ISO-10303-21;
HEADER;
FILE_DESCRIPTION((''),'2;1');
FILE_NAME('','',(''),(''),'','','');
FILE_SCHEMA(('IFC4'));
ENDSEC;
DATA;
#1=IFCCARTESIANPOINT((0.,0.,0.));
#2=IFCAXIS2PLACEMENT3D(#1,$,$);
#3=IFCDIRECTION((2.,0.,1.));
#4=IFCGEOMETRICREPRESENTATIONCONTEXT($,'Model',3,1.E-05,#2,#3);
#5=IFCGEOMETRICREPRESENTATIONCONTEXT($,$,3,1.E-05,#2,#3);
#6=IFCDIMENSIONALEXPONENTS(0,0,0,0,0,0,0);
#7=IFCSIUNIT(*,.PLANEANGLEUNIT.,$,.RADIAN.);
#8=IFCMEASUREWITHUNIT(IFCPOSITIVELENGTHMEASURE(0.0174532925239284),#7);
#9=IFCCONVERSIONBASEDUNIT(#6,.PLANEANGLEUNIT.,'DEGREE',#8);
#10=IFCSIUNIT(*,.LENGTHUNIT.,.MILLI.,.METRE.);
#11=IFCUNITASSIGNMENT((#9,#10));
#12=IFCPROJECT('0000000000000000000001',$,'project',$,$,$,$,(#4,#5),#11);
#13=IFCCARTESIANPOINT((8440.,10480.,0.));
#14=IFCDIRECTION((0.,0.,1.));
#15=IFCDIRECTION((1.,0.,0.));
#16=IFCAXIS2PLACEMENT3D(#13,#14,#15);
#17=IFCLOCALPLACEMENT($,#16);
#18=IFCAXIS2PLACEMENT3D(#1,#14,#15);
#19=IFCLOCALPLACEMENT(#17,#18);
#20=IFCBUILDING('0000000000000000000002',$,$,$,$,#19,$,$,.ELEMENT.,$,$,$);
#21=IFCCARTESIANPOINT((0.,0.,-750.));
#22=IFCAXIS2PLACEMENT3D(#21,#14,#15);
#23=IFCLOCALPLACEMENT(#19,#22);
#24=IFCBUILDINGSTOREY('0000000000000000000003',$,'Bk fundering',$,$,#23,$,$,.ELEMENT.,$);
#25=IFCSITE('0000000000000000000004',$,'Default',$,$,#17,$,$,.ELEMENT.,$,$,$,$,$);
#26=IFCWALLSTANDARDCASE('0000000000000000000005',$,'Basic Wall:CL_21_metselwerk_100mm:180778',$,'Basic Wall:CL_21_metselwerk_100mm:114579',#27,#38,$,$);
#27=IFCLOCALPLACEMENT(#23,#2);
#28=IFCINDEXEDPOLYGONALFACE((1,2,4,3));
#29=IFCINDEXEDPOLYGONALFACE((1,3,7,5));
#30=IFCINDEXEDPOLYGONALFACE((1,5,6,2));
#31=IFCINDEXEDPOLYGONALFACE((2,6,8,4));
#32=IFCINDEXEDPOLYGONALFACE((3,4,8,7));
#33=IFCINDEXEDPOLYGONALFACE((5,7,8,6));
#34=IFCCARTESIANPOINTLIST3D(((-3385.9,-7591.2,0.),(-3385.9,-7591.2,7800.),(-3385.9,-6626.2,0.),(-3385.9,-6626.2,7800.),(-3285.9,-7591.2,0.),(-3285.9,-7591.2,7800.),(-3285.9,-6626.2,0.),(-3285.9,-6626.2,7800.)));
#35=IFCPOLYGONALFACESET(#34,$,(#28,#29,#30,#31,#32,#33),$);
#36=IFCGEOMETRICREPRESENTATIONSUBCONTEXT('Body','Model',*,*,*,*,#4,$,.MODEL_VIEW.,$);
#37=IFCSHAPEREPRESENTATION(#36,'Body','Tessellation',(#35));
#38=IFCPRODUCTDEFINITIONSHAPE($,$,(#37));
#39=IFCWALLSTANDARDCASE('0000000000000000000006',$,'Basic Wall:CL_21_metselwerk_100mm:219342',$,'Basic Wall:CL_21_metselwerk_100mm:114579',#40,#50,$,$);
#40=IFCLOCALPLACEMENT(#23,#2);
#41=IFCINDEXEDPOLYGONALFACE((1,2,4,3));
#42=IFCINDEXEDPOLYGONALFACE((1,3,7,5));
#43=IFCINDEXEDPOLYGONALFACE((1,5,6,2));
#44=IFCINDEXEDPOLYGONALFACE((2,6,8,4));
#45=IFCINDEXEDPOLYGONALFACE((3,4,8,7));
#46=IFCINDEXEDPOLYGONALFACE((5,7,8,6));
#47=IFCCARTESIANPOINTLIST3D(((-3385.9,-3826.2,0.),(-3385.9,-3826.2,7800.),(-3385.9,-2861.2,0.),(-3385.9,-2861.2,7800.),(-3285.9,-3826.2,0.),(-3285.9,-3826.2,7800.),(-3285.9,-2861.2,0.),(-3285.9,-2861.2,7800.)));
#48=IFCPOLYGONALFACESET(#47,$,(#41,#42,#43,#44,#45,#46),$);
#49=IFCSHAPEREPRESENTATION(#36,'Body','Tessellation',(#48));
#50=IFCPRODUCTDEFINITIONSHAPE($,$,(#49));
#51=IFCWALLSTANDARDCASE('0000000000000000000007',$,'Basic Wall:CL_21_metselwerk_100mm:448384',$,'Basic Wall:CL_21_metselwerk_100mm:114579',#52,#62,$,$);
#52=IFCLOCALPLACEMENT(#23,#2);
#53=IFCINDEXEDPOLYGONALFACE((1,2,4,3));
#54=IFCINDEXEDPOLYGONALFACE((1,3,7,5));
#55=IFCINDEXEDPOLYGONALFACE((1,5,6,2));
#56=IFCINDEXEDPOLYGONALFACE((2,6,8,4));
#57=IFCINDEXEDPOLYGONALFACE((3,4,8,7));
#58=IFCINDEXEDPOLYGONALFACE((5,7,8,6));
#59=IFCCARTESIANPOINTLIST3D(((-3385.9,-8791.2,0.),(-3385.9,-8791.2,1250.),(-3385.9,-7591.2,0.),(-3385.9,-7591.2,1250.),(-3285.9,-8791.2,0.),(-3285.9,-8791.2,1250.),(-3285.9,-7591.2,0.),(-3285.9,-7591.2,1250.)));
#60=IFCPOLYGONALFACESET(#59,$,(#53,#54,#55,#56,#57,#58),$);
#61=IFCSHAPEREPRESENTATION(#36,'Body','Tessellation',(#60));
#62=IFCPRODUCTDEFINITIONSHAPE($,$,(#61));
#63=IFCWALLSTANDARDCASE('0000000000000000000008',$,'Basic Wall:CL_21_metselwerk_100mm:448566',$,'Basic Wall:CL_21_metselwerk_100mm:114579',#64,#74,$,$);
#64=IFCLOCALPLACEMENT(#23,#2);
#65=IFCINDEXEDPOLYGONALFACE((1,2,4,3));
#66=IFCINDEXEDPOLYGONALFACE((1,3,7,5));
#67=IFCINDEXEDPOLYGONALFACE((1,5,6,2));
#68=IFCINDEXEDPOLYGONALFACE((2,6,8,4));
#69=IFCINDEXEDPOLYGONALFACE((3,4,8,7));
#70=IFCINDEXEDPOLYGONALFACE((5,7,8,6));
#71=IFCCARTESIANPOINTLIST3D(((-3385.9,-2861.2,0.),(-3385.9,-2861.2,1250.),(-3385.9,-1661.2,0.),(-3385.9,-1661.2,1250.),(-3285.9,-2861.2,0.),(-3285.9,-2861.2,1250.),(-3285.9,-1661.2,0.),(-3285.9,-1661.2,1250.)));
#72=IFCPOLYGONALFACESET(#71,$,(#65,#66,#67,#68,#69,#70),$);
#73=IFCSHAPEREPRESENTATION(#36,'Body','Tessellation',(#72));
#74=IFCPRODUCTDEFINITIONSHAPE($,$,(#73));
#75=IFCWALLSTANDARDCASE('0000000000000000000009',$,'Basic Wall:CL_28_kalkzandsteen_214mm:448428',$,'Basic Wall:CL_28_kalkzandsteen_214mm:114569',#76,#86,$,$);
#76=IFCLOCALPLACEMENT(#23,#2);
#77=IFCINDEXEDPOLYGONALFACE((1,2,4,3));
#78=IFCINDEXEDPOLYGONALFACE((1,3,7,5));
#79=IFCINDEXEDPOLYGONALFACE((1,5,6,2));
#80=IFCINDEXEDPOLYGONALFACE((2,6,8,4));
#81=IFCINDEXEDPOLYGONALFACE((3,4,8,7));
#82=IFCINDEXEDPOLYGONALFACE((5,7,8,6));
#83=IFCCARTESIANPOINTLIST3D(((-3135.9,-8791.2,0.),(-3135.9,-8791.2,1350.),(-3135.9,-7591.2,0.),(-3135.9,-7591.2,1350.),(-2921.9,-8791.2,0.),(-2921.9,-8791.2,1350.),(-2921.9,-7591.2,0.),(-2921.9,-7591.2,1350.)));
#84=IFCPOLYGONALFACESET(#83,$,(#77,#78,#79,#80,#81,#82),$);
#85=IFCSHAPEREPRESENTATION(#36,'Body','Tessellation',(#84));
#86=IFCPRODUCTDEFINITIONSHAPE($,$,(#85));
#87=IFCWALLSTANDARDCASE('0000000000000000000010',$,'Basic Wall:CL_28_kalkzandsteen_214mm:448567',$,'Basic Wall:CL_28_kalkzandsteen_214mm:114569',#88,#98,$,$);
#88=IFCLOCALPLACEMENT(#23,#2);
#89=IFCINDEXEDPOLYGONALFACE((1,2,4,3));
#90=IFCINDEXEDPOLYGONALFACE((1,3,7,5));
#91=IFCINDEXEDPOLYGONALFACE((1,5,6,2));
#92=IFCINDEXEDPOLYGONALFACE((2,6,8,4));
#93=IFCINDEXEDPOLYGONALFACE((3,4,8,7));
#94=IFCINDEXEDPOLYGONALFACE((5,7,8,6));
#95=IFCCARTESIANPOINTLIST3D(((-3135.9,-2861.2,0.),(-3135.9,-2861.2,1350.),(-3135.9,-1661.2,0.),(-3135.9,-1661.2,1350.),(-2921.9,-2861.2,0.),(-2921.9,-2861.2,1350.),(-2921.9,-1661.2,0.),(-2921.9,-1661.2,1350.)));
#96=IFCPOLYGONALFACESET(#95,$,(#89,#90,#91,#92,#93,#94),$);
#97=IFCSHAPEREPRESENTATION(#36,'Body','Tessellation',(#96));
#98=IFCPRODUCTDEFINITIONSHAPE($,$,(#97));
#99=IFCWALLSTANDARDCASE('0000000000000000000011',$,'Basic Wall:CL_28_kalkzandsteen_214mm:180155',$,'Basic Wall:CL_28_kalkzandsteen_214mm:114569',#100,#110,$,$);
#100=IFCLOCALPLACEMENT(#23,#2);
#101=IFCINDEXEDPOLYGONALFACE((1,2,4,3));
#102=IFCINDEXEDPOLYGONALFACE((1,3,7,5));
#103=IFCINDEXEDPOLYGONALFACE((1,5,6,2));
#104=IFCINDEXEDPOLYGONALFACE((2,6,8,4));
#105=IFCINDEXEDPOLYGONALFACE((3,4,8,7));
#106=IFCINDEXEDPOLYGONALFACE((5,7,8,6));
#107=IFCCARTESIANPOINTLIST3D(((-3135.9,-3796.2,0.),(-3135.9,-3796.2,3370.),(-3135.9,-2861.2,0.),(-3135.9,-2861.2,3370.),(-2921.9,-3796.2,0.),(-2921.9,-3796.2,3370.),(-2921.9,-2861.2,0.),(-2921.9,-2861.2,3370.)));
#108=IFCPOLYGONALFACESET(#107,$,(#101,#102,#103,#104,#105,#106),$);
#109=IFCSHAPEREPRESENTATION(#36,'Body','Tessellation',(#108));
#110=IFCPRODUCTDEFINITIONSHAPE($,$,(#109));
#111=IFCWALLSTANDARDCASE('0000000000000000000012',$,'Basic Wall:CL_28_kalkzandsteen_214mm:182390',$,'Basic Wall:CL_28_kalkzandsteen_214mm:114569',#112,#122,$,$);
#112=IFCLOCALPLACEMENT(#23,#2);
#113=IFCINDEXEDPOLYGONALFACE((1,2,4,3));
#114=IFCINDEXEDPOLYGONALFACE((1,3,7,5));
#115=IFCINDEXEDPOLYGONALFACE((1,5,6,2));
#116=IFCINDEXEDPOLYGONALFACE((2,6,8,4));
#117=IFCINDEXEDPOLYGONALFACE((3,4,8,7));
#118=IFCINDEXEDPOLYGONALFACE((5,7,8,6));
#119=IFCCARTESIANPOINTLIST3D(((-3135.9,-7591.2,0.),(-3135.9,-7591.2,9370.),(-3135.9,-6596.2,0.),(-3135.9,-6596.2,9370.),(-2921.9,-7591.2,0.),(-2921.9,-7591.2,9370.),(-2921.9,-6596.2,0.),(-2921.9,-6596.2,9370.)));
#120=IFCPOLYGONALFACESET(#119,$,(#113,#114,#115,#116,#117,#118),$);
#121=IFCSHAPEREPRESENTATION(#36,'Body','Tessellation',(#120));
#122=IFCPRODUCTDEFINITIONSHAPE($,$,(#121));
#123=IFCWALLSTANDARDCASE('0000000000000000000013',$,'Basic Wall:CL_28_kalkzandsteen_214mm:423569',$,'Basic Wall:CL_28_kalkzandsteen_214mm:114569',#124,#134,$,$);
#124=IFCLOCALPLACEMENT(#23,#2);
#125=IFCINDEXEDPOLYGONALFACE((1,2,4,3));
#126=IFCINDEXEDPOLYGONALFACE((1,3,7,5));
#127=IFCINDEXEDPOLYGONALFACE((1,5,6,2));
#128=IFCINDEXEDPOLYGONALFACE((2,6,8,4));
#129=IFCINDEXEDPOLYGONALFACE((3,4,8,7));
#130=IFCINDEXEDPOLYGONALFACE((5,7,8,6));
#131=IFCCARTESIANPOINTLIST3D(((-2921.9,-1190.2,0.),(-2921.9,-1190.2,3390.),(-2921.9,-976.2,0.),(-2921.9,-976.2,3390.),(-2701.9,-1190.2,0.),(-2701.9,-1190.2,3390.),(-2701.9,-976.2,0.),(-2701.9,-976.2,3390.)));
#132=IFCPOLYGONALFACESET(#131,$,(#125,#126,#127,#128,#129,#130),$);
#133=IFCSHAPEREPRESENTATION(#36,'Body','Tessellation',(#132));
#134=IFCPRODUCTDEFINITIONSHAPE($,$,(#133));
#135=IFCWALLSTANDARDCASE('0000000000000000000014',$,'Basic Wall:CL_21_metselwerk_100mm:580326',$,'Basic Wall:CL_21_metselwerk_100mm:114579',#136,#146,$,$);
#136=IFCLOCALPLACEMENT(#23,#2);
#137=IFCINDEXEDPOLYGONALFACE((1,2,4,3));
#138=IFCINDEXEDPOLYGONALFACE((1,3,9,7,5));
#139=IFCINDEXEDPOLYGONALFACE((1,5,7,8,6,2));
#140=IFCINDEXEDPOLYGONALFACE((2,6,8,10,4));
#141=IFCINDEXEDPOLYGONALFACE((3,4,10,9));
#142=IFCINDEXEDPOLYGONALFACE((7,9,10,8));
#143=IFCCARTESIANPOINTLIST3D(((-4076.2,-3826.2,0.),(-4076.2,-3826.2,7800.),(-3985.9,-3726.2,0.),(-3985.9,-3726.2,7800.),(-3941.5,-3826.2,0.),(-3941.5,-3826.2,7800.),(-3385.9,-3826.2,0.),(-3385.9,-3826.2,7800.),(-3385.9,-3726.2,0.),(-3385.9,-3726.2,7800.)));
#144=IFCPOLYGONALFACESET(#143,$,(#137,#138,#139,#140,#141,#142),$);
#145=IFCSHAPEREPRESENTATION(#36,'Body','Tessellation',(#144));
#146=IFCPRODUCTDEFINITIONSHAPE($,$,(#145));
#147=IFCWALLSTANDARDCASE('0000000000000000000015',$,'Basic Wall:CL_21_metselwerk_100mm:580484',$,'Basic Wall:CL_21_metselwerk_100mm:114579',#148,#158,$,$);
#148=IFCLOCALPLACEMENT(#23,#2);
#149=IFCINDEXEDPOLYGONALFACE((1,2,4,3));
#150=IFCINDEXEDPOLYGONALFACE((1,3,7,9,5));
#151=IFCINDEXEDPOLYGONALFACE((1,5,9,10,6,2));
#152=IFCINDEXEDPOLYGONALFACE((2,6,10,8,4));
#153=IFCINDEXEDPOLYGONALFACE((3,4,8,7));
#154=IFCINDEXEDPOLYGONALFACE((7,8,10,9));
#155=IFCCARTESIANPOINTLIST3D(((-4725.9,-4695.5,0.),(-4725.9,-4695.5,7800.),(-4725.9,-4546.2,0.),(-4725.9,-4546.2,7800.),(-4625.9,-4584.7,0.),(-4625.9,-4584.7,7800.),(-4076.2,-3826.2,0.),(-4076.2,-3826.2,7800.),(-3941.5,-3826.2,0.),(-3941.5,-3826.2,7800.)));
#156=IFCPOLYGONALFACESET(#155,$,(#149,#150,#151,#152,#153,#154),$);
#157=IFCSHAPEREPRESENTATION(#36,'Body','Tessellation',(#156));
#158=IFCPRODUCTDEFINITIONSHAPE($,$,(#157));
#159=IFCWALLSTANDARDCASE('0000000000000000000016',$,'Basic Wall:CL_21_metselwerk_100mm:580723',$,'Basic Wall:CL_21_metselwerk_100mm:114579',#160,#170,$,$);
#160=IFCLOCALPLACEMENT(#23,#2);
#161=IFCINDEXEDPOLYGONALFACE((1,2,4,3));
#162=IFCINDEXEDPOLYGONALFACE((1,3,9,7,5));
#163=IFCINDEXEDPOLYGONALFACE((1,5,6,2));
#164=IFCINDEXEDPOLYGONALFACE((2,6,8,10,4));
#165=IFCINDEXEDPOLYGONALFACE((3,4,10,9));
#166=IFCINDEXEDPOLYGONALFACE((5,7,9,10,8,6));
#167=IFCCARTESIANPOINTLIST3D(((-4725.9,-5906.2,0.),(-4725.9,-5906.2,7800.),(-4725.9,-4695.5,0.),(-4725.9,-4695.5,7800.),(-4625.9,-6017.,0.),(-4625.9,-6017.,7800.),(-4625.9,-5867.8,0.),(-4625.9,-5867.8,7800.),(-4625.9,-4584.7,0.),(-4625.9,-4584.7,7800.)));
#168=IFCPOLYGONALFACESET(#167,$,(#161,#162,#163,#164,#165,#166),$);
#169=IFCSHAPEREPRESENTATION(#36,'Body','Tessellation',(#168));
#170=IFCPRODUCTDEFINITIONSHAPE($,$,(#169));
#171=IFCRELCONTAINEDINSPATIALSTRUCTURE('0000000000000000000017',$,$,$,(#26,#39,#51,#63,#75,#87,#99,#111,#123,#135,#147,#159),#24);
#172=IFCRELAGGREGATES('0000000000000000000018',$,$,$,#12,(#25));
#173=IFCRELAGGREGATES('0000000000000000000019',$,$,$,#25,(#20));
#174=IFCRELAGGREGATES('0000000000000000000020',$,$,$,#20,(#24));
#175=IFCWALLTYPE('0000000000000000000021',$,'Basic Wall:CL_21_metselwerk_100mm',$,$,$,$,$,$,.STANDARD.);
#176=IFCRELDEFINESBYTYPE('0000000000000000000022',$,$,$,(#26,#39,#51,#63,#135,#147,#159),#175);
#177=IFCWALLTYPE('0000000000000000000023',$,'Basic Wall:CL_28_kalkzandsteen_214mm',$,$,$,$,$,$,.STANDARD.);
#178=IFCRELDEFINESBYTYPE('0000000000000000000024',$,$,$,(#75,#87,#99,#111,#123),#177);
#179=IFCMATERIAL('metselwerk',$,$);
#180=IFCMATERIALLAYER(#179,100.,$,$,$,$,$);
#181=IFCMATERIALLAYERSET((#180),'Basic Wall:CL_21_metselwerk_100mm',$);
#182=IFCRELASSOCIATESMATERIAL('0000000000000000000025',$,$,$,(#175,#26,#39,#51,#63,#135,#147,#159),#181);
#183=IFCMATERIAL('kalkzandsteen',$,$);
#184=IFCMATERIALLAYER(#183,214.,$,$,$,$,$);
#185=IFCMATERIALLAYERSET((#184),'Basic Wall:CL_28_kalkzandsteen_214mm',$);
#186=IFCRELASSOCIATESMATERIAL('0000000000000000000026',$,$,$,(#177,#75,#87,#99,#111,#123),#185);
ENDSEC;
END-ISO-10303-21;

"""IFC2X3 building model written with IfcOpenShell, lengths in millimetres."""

from ifc_helpers import new_model, entity, si_unit, converted_unit, direction, frame, frame_2d, origin, origin_with_axes, place, context, subcontext, project, spatial, polyline, rectangle, outline, extrude, clip, bounded_halfspace, source, transform, mapped, material, layer, layer_set, layer_usage, type_object, element, save


model = new_model("IFC2X3")

# Units and contexts
model_context = context("Model", 3, precision=1e-05, world=origin(), true_north=direction((2.0, 0.0, 1.0)))
context_of_model = context(None, 3, precision=1e-05, world=origin(), true_north=direction((2.0, 0.0, 1.0)))
body_context = subcontext(model_context, "Body", "Model", "MODEL_VIEW")
ifc_project = project(units=[converted_unit("PLANEANGLEUNIT", "DEGREE", entity("IfcPositiveLengthMeasure", 0.0174532925239284), si_unit("PLANEANGLEUNIT", "RADIAN"), dimensions=[0, 0, 0, 0, 0, 0, 0]), si_unit("LENGTHUNIT", "METRE", prefix="MILLI")], contexts=[model_context, context_of_model])

# Site, building, storey
site_placement = place(None, frame((8440.0, 10480.0, 0.0), z_axis=(0.0, 0.0, 1.0), x_axis=(1.0, 0.0, 0.0)))
site = spatial("IfcSite", under=ifc_project, at=site_placement, Name="Default", CompositionType="ELEMENT")
building_placement = place(site_placement, origin_with_axes())
building = spatial("IfcBuilding", under=site, at=building_placement, CompositionType="ELEMENT")
storey_placement = place(building_placement, frame((0.0, 0.0, -750.0), z_axis=(0.0, 0.0, 1.0), x_axis=(1.0, 0.0, 0.0)))
storey = spatial("IfcBuildingStorey", under=building, at=storey_placement, Name="Bk fundering", CompositionType="ELEMENT")

# Walls
ifc_material_1 = material(Name="metselwerk")
ifc_layer_1 = layer(ifc_material_1, 100.0)
ifc_layer_set_1 = layer_set([ifc_layer_1], Name="Basic Wall:CL_21_metselwerk_100mm")
ifc_layer_usage_1 = layer_usage(ifc_layer_set_1, "AXIS2", "NEGATIVE", 50.0)
wall_type_1 = type_object("IfcWallType", Name="Basic Wall:CL_21_metselwerk_100mm", PredefinedType="STANDARD", material=ifc_layer_set_1)
shared_shape_1 = source(origin(), body_context, "Body", "SweptSolid", [
    extrude(rectangle(XDim=965.0, YDim=100.0, at=frame_2d((482.5, 0.0), x_axis=(-1.0, 0.0))), origin(), (0.0, 0.0, 1.0), 7800.0),
])
wall_1_placement = place(storey_placement, frame((-3335.9, -6626.2, 0.0), z_axis=(0.0, 0.0, 1.0), x_axis=(0.0, -1.0, 0.0)))
element("IfcWallStandardCase", 1, at=wall_1_placement, inside=storey, type_object=wall_type_1, material=ifc_layer_usage_1, Name="Basic Wall:CL_21_metselwerk_100mm:180778", ObjectType="Basic Wall:CL_21_metselwerk_100mm:114579", context=body_context, shape_type="MappedRepresentation", body=[
    mapped(shared_shape_1, transform((0.0, 0.0, 0.0))),
])
ifc_layer_usage_2 = layer_usage(ifc_layer_set_1, "AXIS2", "NEGATIVE", 50.0)
wall_2_placement = place(storey_placement, frame((-3335.9, -2861.2, 0.0), z_axis=(0.0, 0.0, 1.0), x_axis=(0.0, -1.0, 0.0)))
element("IfcWallStandardCase", 2, at=wall_2_placement, inside=storey, type_object=wall_type_1, material=ifc_layer_usage_2, Name="Basic Wall:CL_21_metselwerk_100mm:219342", ObjectType="Basic Wall:CL_21_metselwerk_100mm:114579", context=body_context, shape_type="MappedRepresentation", body=[
    mapped(shared_shape_1, transform((0.0, 0.0, 0.0))),
])
ifc_layer_usage_3 = layer_usage(ifc_layer_set_1, "AXIS2", "NEGATIVE", 50.0)
shared_shape_2 = source(origin(), body_context, "Body", "SweptSolid", [
    extrude(rectangle(XDim=1200.0, YDim=100.0, at=frame_2d((600.0, 0.0), x_axis=(-1.0, 0.0))), origin(), (0.0, 0.0, 1.0), 1250.0),
])
wall_3_placement = place(storey_placement, frame((-3335.9, -8791.2, 0.0), z_axis=(0.0, 0.0, 1.0), x_axis=(0.0, 1.0, 0.0)))
element("IfcWallStandardCase", 3, at=wall_3_placement, inside=storey, type_object=wall_type_1, material=ifc_layer_usage_3, Name="Basic Wall:CL_21_metselwerk_100mm:448384", ObjectType="Basic Wall:CL_21_metselwerk_100mm:114579", context=body_context, shape_type="MappedRepresentation", body=[
    mapped(shared_shape_2, transform((0.0, 0.0, 0.0))),
])
ifc_layer_usage_4 = layer_usage(ifc_layer_set_1, "AXIS2", "NEGATIVE", 50.0)
wall_4_placement = place(storey_placement, frame((-3335.9, -2861.2, 0.0), z_axis=(0.0, 0.0, 1.0), x_axis=(0.0, 1.0, 0.0)))
element("IfcWallStandardCase", 4, at=wall_4_placement, inside=storey, type_object=wall_type_1, material=ifc_layer_usage_4, Name="Basic Wall:CL_21_metselwerk_100mm:448566", ObjectType="Basic Wall:CL_21_metselwerk_100mm:114579", context=body_context, shape_type="MappedRepresentation", body=[
    mapped(shared_shape_2, transform((0.0, 0.0, 0.0))),
])
ifc_material_2 = material(Name="kalkzandsteen")
ifc_layer_2 = layer(ifc_material_2, 214.0)
ifc_layer_set_2 = layer_set([ifc_layer_2], Name="Basic Wall:CL_28_kalkzandsteen_214mm")
ifc_layer_usage_5 = layer_usage(ifc_layer_set_2, "AXIS2", "NEGATIVE", 107.0)
wall_type_2 = type_object("IfcWallType", Name="Basic Wall:CL_28_kalkzandsteen_214mm", PredefinedType="STANDARD", material=ifc_layer_set_2)
shared_shape_3 = source(origin(), body_context, "Body", "SweptSolid", [
    extrude(rectangle(XDim=1200.0, YDim=214.0, at=frame_2d((600.0, 0.0), x_axis=(-1.0, 0.0))), origin(), (0.0, 0.0, 1.0), 1350.0),
])
wall_5_placement = place(storey_placement, frame((-3028.9, -8791.2, 0.0), z_axis=(0.0, 0.0, 1.0), x_axis=(0.0, 1.0, 0.0)))
element("IfcWallStandardCase", 5, at=wall_5_placement, inside=storey, type_object=wall_type_2, material=ifc_layer_usage_5, Name="Basic Wall:CL_28_kalkzandsteen_214mm:448428", ObjectType="Basic Wall:CL_28_kalkzandsteen_214mm:114569", context=body_context, shape_type="MappedRepresentation", body=[
    mapped(shared_shape_3, transform((0.0, 0.0, 0.0))),
])
ifc_layer_usage_6 = layer_usage(ifc_layer_set_2, "AXIS2", "NEGATIVE", 107.0)
wall_6_placement = place(storey_placement, frame((-3028.9, -2861.2, 0.0), z_axis=(0.0, 0.0, 1.0), x_axis=(0.0, 1.0, 0.0)))
element("IfcWallStandardCase", 6, at=wall_6_placement, inside=storey, type_object=wall_type_2, material=ifc_layer_usage_6, Name="Basic Wall:CL_28_kalkzandsteen_214mm:448567", ObjectType="Basic Wall:CL_28_kalkzandsteen_214mm:114569", context=body_context, shape_type="MappedRepresentation", body=[
    mapped(shared_shape_3, transform((0.0, 0.0, 0.0))),
])
ifc_layer_usage_7 = layer_usage(ifc_layer_set_2, "AXIS2", "NEGATIVE", 107.0)
wall_7_placement = place(storey_placement, frame((-3028.9, -2861.2, 0.0), z_axis=(0.0, 0.0, 1.0), x_axis=(0.0, -1.0, 0.0)))
element("IfcWallStandardCase", 7, at=wall_7_placement, inside=storey, type_object=wall_type_2, material=ifc_layer_usage_7, Name="Basic Wall:CL_28_kalkzandsteen_214mm:180155", ObjectType="Basic Wall:CL_28_kalkzandsteen_214mm:114569", context=body_context, shape_type="Clipping", body=[
    clip(extrude(rectangle(XDim=935.0, YDim=214.0, at=frame_2d((467.5, 0.0), x_axis=(-1.0, 0.0))), origin(), (0.0, 0.0, 1.0), 3370.0), bounded_halfspace(frame((0.0, -107.0, 3370.0), z_axis=(0.0, 0.0, -1.0), x_axis=(0.0, 1.0, 0.0)), True, frame((0.0, -107.0, 3370.0)), polyline([(0.0, 0.0), (935.0, 0.0), (935.0, 214.0), (0.0, 214.0), (0.0, 0.0)]))),
])
ifc_layer_usage_8 = layer_usage(ifc_layer_set_2, "AXIS2", "NEGATIVE", 107.0)
wall_8_placement = place(storey_placement, frame((-3028.9, -6596.2, 0.0), z_axis=(0.0, 0.0, 1.0), x_axis=(0.0, -1.0, 0.0)))
element("IfcWallStandardCase", 8, at=wall_8_placement, inside=storey, type_object=wall_type_2, material=ifc_layer_usage_8, Name="Basic Wall:CL_28_kalkzandsteen_214mm:182390", ObjectType="Basic Wall:CL_28_kalkzandsteen_214mm:114569", context=body_context, shape_type="Clipping", body=[
    clip(extrude(rectangle(XDim=995.0, YDim=214.0, at=frame_2d((497.5, 0.0), x_axis=(-1.0, 0.0))), origin(), (0.0, 0.0, 1.0), 9370.0), bounded_halfspace(frame((0.0, -107.0, 9370.0), z_axis=(0.0, 0.0, -1.0), x_axis=(0.0, 1.0, 0.0)), True, frame((0.0, -107.0, 9370.0)), polyline([(0.0, 0.0), (995.0, 0.0), (995.0, 214.0), (0.0, 214.0), (0.0, 0.0)]))),
])
ifc_layer_usage_9 = layer_usage(ifc_layer_set_2, "AXIS2", "NEGATIVE", 107.0)
wall_9_placement = place(storey_placement, frame((-2701.9, -1083.2, 0.0), z_axis=(0.0, 0.0, 1.0), x_axis=(-1.0, 0.0, 0.0)))
element("IfcWallStandardCase", 9, at=wall_9_placement, inside=storey, type_object=wall_type_2, material=ifc_layer_usage_9, Name="Basic Wall:CL_28_kalkzandsteen_214mm:423569", ObjectType="Basic Wall:CL_28_kalkzandsteen_214mm:114569", context=body_context, shape_type="SweptSolid", body=[
    extrude(rectangle(XDim=220.0, YDim=214.0, at=frame_2d((110.0, 0.0), x_axis=(-1.0, 0.0))), origin(), (0.0, 0.0, 1.0), 3390.0),
])
ifc_layer_usage_10 = layer_usage(ifc_layer_set_1, "AXIS2", "NEGATIVE", 50.0)
wall_10_placement = place(storey_placement, frame((-3385.9, -3776.2, 0.0), z_axis=(0.0, 0.0, 1.0), x_axis=(-1.0, 0.0, 0.0)))
element("IfcWallStandardCase", 10, at=wall_10_placement, inside=storey, type_object=wall_type_1, material=ifc_layer_usage_10, Name="Basic Wall:CL_21_metselwerk_100mm:580326", ObjectType="Basic Wall:CL_21_metselwerk_100mm:114579", context=body_context, shape_type="SweptSolid", body=[
    extrude(outline(polyline([(600.0, -50.0), (690.3, 50.0), (555.6, 50.0), (0.0, 50.0), (0.0, -50.0), (600.0, -50.0)])), origin(), (0.0, 0.0, 1.0), 7800.0),
])
ifc_layer_usage_11 = layer_usage(ifc_layer_set_1, "AXIS2", "NEGATIVE", 50.0)
wall_11_placement = place(storey_placement, frame((-3978.6, -3792.7, 0.0), z_axis=(0.0, 0.0, 1.0), x_axis=(-0.669965, -0.742393, 0.0)))
element("IfcWallStandardCase", 11, at=wall_11_placement, inside=storey, type_object=wall_type_1, material=ifc_layer_usage_11, Name="Basic Wall:CL_21_metselwerk_100mm:580484", ObjectType="Basic Wall:CL_21_metselwerk_100mm:114579", context=body_context, shape_type="SweptSolid", body=[
    extrude(outline(polyline([(1060.1, -50.0), (1170.9, 50.0), (1021.6, 50.0), (0.0, 50.0), (90.2, -50.0), (1060.1, -50.0)])), origin(), (0.0, 0.0, 1.0), 7800.0),
])
ifc_layer_usage_12 = layer_usage(ifc_layer_set_1, "AXIS2", "NEGATIVE", 50.0)
wall_12_placement = place(storey_placement, frame((-4675.9, -4584.7, 0.0), z_axis=(0.0, 0.0, 1.0), x_axis=(0.0, -1.0, 0.0)))
element("IfcWallStandardCase", 12, at=wall_12_placement, inside=storey, type_object=wall_type_1, material=ifc_layer_usage_12, Name="Basic Wall:CL_21_metselwerk_100mm:580723", ObjectType="Basic Wall:CL_21_metselwerk_100mm:114579", context=body_context, shape_type="SweptSolid", body=[
    extrude(outline(polyline([(1321.5, -50.0), (1432.4, 50.0), (1283.1, 50.0), (0.0, 50.0), (110.8, -50.0), (1321.5, -50.0)])), origin(), (0.0, 0.0, 1.0), 7800.0),
])

save(model, "model.ifc")
